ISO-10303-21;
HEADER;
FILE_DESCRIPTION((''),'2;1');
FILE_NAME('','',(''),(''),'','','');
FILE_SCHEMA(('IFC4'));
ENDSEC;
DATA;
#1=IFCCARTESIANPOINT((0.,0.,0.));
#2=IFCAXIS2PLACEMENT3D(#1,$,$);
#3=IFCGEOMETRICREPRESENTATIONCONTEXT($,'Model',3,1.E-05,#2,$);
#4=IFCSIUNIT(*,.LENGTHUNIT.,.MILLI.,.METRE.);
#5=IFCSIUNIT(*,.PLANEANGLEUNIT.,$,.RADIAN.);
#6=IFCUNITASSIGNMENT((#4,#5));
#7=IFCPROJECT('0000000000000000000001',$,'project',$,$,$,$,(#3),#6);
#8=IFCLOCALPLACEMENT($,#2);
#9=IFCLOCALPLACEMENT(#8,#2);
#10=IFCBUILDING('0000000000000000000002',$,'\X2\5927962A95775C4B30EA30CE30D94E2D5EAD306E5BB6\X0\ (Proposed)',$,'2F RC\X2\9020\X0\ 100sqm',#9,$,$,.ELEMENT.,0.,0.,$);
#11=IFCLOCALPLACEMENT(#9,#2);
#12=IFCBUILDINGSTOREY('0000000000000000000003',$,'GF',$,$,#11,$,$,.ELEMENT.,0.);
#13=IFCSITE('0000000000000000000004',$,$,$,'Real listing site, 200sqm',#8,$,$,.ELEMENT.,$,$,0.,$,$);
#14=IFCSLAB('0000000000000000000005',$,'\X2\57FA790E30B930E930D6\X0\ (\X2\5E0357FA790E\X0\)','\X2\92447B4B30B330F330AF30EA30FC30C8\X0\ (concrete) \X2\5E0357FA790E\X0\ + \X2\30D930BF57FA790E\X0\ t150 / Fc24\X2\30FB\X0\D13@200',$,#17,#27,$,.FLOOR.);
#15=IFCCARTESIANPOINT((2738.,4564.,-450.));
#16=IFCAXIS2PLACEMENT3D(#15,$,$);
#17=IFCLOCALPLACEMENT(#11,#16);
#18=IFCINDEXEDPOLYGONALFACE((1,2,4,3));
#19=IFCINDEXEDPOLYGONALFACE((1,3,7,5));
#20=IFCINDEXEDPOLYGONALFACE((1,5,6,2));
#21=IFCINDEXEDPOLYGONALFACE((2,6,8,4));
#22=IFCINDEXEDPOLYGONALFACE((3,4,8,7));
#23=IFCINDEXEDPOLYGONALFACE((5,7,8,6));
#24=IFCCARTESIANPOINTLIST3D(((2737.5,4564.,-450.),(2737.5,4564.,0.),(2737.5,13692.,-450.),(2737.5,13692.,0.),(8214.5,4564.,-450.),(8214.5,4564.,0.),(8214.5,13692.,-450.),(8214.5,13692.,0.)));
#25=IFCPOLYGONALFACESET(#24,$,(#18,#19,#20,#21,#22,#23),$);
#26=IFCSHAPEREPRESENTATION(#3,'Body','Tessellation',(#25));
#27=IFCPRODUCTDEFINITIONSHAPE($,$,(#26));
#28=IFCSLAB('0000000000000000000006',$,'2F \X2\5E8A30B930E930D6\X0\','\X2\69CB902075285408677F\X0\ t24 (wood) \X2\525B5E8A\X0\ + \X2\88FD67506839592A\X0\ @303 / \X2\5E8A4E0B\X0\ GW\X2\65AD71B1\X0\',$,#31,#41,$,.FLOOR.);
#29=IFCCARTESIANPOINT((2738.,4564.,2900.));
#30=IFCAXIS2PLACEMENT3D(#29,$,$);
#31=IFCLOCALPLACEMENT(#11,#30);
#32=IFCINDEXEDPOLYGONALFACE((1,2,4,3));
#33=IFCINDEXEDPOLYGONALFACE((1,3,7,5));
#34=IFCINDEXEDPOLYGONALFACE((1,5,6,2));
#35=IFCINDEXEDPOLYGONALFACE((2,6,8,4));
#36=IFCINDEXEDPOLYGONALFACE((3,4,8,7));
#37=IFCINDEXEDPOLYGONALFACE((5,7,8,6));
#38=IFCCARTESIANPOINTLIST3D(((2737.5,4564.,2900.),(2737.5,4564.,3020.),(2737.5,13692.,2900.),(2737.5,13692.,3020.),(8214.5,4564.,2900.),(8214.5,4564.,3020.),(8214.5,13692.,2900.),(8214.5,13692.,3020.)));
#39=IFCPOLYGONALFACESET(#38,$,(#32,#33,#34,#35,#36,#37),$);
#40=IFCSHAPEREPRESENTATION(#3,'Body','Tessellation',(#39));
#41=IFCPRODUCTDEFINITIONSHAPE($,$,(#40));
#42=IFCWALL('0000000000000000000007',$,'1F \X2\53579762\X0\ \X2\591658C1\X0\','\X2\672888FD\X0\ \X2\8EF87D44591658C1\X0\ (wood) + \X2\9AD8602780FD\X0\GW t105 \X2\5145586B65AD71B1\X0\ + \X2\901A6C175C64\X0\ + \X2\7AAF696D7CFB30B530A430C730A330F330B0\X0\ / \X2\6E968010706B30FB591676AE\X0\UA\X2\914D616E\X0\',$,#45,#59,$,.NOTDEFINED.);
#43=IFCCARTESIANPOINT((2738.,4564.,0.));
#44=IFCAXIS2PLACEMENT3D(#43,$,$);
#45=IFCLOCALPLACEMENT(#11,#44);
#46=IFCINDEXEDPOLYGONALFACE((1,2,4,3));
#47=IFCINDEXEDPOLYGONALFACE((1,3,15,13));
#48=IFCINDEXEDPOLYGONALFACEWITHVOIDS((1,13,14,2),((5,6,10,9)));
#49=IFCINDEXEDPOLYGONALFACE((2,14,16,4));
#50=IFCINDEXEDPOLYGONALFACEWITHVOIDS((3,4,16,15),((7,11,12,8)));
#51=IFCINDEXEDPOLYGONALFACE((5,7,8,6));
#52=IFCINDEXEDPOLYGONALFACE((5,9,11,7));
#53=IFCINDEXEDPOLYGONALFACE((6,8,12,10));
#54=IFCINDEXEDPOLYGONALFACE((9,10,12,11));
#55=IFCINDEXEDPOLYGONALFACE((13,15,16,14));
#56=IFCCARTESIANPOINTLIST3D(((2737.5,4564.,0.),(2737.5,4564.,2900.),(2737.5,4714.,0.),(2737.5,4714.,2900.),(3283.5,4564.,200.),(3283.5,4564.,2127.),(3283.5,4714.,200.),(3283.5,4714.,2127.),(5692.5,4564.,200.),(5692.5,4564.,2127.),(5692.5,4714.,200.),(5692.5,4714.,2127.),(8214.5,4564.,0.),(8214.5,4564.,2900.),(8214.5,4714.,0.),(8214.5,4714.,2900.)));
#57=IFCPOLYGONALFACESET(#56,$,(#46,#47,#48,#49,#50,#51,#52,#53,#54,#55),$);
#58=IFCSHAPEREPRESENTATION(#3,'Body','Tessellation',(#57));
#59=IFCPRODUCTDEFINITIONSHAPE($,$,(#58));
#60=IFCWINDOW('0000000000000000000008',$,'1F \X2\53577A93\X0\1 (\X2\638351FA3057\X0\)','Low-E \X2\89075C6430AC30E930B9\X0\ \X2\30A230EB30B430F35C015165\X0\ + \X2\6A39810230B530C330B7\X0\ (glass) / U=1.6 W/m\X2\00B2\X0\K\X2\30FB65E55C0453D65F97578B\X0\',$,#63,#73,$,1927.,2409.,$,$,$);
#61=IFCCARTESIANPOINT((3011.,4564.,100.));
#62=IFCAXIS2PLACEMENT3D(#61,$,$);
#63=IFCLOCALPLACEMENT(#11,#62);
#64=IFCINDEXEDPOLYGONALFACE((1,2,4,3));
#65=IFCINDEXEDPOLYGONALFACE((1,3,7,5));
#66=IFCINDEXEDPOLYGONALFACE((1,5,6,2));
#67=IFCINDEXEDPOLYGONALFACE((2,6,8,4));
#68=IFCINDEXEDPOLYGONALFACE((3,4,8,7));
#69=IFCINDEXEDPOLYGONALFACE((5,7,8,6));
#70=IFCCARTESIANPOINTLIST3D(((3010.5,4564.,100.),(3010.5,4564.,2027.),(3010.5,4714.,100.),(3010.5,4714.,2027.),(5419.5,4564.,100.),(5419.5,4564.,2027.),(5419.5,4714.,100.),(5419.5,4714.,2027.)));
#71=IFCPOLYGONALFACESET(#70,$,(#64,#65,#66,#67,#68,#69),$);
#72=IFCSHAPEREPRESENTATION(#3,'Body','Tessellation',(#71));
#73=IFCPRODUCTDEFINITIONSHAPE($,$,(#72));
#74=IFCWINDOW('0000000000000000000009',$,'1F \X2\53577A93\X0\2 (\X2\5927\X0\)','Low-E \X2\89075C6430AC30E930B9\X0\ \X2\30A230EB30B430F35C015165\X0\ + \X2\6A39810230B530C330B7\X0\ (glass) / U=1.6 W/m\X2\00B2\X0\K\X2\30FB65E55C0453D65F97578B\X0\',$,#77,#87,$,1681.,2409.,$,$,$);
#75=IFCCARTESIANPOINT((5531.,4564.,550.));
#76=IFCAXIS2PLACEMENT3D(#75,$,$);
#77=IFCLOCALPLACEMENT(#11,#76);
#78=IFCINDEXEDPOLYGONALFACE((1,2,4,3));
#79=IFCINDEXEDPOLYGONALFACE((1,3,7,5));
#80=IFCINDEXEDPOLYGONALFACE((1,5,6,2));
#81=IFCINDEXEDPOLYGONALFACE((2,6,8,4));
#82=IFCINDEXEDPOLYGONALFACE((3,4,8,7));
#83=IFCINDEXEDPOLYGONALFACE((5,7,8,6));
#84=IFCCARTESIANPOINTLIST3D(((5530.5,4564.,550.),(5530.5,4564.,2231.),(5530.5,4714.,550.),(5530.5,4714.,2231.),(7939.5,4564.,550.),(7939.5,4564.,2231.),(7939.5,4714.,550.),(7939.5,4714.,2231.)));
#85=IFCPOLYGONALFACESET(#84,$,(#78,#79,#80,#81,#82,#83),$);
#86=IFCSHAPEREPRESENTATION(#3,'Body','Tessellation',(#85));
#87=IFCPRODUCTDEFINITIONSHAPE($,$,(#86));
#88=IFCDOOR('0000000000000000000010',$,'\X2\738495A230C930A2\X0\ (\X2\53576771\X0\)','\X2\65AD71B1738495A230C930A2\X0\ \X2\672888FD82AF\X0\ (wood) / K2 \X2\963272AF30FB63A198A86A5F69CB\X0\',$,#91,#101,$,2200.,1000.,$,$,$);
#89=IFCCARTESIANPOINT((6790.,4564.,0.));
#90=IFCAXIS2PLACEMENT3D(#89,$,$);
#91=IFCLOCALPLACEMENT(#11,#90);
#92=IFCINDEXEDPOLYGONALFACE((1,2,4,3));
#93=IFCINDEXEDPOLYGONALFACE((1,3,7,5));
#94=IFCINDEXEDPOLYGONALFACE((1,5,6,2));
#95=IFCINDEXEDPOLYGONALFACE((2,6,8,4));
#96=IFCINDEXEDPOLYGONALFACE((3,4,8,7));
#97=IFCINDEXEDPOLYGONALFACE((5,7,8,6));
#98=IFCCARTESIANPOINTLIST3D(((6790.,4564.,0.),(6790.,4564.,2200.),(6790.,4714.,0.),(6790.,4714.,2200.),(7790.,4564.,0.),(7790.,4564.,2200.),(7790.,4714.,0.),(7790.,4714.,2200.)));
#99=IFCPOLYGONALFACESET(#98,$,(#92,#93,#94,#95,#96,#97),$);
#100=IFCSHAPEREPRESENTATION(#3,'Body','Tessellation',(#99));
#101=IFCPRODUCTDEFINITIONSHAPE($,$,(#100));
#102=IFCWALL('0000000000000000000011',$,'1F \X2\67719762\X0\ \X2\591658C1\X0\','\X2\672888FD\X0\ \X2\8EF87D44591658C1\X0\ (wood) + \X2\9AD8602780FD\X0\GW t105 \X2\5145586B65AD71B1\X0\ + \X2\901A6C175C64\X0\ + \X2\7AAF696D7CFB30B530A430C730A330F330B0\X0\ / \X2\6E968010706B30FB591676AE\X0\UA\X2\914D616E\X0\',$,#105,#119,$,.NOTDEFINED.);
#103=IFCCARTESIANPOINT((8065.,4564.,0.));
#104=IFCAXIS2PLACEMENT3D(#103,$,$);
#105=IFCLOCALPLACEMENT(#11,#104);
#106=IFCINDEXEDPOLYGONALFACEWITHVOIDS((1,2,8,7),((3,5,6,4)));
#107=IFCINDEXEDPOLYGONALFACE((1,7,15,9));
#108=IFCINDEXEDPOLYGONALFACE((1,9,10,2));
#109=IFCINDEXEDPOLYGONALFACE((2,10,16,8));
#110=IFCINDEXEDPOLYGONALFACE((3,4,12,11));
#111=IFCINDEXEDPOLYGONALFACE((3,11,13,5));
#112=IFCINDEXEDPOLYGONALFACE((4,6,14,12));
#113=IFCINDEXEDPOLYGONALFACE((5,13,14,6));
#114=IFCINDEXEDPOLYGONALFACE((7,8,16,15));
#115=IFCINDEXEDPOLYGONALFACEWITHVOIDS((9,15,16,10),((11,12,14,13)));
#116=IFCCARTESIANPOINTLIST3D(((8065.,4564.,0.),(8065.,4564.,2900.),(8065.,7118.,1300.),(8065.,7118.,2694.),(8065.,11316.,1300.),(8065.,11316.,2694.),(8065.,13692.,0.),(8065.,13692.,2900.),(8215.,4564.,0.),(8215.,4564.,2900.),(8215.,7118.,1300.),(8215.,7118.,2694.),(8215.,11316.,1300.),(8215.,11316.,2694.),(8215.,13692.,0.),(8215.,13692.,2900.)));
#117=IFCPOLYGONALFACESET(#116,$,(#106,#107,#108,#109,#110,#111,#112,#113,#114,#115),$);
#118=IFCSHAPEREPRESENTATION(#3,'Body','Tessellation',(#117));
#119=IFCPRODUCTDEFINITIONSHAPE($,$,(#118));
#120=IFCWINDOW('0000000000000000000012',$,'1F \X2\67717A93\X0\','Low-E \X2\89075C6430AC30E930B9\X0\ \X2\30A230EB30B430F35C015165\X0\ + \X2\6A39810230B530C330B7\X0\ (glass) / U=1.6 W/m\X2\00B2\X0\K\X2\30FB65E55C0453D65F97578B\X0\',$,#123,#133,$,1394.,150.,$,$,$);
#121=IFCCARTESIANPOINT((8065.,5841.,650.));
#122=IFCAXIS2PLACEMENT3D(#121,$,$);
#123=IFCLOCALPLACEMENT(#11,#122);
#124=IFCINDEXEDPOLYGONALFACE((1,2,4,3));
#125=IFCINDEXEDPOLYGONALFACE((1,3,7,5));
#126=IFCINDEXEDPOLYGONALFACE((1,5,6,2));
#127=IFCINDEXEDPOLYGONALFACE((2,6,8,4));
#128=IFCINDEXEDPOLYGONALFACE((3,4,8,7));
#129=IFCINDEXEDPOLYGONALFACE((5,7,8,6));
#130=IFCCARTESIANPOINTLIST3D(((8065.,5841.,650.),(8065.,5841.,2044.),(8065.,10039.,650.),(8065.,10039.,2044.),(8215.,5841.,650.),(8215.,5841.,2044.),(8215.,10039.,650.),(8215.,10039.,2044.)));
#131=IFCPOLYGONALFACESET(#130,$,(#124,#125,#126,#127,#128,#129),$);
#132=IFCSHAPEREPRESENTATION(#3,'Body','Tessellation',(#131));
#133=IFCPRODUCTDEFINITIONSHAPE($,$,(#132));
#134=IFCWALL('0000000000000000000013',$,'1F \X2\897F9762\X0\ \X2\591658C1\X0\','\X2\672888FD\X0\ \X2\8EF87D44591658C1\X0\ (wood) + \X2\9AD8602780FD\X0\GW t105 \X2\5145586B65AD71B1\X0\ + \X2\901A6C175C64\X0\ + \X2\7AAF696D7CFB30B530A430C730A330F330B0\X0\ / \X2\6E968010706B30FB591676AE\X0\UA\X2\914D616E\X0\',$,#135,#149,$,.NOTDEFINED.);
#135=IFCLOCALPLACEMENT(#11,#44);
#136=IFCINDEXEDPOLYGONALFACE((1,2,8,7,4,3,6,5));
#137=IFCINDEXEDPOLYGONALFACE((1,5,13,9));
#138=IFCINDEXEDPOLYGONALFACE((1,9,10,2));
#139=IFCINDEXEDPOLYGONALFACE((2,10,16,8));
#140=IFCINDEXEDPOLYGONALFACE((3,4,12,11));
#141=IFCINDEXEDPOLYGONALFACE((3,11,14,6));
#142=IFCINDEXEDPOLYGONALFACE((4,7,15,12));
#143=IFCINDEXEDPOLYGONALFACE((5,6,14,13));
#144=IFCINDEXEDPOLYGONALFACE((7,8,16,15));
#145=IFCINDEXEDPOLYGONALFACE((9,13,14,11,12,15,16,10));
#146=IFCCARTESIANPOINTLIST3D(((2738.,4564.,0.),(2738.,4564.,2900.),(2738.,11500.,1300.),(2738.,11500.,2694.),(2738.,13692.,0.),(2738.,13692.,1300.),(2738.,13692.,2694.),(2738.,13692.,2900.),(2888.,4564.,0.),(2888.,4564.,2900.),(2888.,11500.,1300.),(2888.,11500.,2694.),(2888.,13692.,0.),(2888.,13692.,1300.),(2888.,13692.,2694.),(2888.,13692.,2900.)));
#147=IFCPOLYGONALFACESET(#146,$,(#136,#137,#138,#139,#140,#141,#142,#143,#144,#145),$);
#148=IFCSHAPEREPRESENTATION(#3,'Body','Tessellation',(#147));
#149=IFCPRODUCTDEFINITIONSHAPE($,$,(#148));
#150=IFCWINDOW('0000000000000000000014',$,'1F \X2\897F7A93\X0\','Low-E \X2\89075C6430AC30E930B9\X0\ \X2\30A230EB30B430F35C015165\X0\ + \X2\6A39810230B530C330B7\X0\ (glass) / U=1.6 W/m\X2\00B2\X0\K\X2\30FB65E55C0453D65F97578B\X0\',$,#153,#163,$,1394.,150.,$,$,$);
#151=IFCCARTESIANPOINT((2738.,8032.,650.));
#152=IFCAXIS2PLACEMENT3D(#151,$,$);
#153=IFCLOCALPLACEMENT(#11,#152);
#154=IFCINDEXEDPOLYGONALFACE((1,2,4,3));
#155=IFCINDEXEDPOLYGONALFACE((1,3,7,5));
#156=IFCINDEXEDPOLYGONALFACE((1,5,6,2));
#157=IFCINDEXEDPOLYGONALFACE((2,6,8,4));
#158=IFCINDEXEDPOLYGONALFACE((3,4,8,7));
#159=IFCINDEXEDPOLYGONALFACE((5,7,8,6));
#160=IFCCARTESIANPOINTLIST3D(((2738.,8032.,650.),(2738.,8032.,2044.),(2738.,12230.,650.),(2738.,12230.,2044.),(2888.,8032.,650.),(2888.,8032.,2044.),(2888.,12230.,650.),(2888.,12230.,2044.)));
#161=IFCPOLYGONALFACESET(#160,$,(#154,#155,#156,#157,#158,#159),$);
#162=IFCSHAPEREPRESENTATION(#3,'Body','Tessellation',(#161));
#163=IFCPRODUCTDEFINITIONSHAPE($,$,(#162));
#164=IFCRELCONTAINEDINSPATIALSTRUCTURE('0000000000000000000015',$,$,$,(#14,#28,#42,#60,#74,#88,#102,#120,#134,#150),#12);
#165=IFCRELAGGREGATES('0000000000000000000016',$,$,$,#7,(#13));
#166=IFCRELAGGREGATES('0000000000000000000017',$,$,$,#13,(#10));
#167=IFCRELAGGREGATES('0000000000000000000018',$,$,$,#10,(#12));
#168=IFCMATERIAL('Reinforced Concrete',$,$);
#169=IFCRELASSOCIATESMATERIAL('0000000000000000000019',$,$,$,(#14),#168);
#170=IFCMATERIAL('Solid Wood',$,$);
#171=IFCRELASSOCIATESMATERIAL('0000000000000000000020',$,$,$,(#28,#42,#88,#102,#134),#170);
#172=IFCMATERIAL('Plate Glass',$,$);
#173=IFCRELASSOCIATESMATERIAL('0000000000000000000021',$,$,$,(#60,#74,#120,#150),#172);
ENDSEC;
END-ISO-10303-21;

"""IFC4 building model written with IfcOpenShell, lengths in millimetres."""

from ifc_helpers import new_model, si_unit, frame, frame_2d, origin, place, context, project, spatial, rectangle, extrude, material, element, fill, save


model = new_model("IFC4")

# Units and contexts
model_context = context("Model", 3, precision=1e-05, world=origin())
ifc_project = project(units=[si_unit("LENGTHUNIT", "METRE", prefix="MILLI"), si_unit("PLANEANGLEUNIT", "RADIAN")], contexts=[model_context])

# Site, building, storey
site_placement = place(None, origin())
site = spatial("IfcSite", under=ifc_project, at=site_placement, ObjectType="Real listing site, 200sqm", CompositionType="ELEMENT", RefElevation=0.0)
building_placement = place(site_placement, origin())
building = spatial("IfcBuilding", under=site, at=building_placement, Name="大阪長屋リノベ中庭の家 (Proposed)", ObjectType="2F RC造 100sqm", CompositionType="ELEMENT", ElevationOfRefHeight=0.0, ElevationOfTerrain=0.0)
storey_placement = place(building_placement, origin())
storey = spatial("IfcBuildingStorey", under=building, at=storey_placement, Name="GF", CompositionType="ELEMENT", Elevation=0.0)

# Slabs
ifc_material_1 = material(Name="Reinforced Concrete")
slab_1_placement = place(storey_placement, frame((2738.0, 4564.0, -450.0)))
element("IfcSlab", 1, at=slab_1_placement, inside=storey, material=ifc_material_1, Name="基礎スラブ (布基礎)", Description="鉄筋コンクリート (concrete) 布基礎 + ベタ基礎 t150 / Fc24・D13@200", PredefinedType="FLOOR", context=model_context, shape_type="SweptSolid", body=[
    extrude(rectangle(XDim=5477.0, YDim=9128.0, at=frame_2d((2738.0, 4564.0))), frame((2738.0, 4564.0, -450.0)), (0.0, 0.0, 1.0), 450.0),
])
ifc_material_2 = material(Name="Solid Wood")
slab_2_placement = place(storey_placement, frame((2738.0, 4564.0, 2900.0)))
element("IfcSlab", 2, at=slab_2_placement, inside=storey, material=ifc_material_2, Name="2F 床スラブ", Description="構造用合板 t24 (wood) 剛床 + 製材根太 @303 / 床下 GW断熱", PredefinedType="FLOOR", context=model_context, shape_type="SweptSolid", body=[
    extrude(rectangle(XDim=5477.0, YDim=9128.0, at=frame_2d((2738.0, 4564.0))), frame((2738.0, 4564.0, 2900.0)), (0.0, 0.0, 1.0), 120.0),
])

# Wall, openings, windows, door
wall_1_placement = place(storey_placement, frame((2738.0, 4564.0, 0.0)))
wall_1 = element("IfcWall", 3, at=wall_1_placement, inside=storey, material=ifc_material_2, Name="1F 南面 外壁", Description="木製 軸組外壁 (wood) + 高性能GW t105 充填断熱 + 通気層 + 窯業系サイディング / 準耐火・外皮UA配慮", PredefinedType="NOTDEFINED", context=model_context, shape_type="SweptSolid", body=[
    extrude(rectangle(XDim=5477.0, YDim=150.0, at=frame_2d((2738.0, 75.0))), frame((2738.0, 4564.0, 0.0)), (0.0, 0.0, 1.0), 2900.0),
])
opening_1_placement = place(storey_placement, frame((3011.0, 4564.0, 100.0)))
opening_1 = element("IfcOpeningElement", 4, at=opening_1_placement, cuts=wall_1, PredefinedType="NOTDEFINED", context=model_context, shape_type="SweptSolid", body=[
    extrude(rectangle(XDim=2409.0, YDim=150.0, at=frame_2d((1204.0, 75.0))), frame((3011.0, 4564.0, 100.0)), (0.0, 0.0, 1.0), 1927.0),
])
opening_2_placement = place(storey_placement, frame((5531.0, 4564.0, 550.0)))
opening_2 = element("IfcOpeningElement", 5, at=opening_2_placement, cuts=wall_1, PredefinedType="NOTDEFINED", context=model_context, shape_type="SweptSolid", body=[
    extrude(rectangle(XDim=2409.0, YDim=150.0, at=frame_2d((1204.0, 75.0))), frame((5531.0, 4564.0, 550.0)), (0.0, 0.0, 1.0), 1681.0),
])
opening_3_placement = place(storey_placement, frame((6790.0, 4564.0, 0.0)))
opening_3 = element("IfcOpeningElement", 6, at=opening_3_placement, cuts=wall_1, PredefinedType="NOTDEFINED", context=model_context, shape_type="SweptSolid", body=[
    extrude(rectangle(XDim=1000.0, YDim=150.0, at=frame_2d((500.0, 75.0))), frame((6790.0, 4564.0, 0.0)), (0.0, 0.0, 1.0), 2200.0),
])
ifc_material_3 = material(Name="Plate Glass")
window_1_placement = place(storey_placement, frame((3011.0, 4564.0, 100.0)))
window_1 = element("IfcWindow", 7, at=window_1_placement, inside=storey, material=ifc_material_3, Name="1F 南窓1 (掃出し)", Description="Low-E 複層ガラス アルゴン封入 + 樹脂サッシ (glass) / U=1.6 W/m²K・日射取得型", OverallHeight=1927.0, OverallWidth=2409.0, context=model_context, shape_type="SweptSolid", body=[
    extrude(rectangle(XDim=2409.0, YDim=150.0, at=frame_2d((1204.0, 75.0))), frame((3011.0, 4564.0, 100.0)), (0.0, 0.0, 1.0), 1927.0),
])
fill(opening_1, window_1)
window_2_placement = place(storey_placement, frame((5531.0, 4564.0, 550.0)))
window_2 = element("IfcWindow", 8, at=window_2_placement, inside=storey, material=ifc_material_3, Name="1F 南窓2 (大)", Description="Low-E 複層ガラス アルゴン封入 + 樹脂サッシ (glass) / U=1.6 W/m²K・日射取得型", OverallHeight=1681.0, OverallWidth=2409.0, context=model_context, shape_type="SweptSolid", body=[
    extrude(rectangle(XDim=2409.0, YDim=150.0, at=frame_2d((1204.0, 75.0))), frame((5531.0, 4564.0, 550.0)), (0.0, 0.0, 1.0), 1681.0),
])
fill(opening_2, window_2)
door_placement = place(storey_placement, frame((6790.0, 4564.0, 0.0)))
door = element("IfcDoor", 9, at=door_placement, inside=storey, material=ifc_material_2, Name="玄関ドア (南東)", Description="断熱玄関ドア 木製芯 (wood) / K2 防犯・採風機構", OverallHeight=2200.0, OverallWidth=1000.0, context=model_context, shape_type="SweptSolid", body=[
    extrude(rectangle(XDim=1000.0, YDim=150.0, at=frame_2d((500.0, 75.0))), frame((6790.0, 4564.0, 0.0)), (0.0, 0.0, 1.0), 2200.0),
])
fill(opening_3, door)

# Walls, openings, windows
wall_2_placement = place(storey_placement, frame((8065.0, 4564.0, 0.0)))
wall_2 = element("IfcWall", 10, at=wall_2_placement, inside=storey, material=ifc_material_2, Name="1F 東面 外壁", Description="木製 軸組外壁 (wood) + 高性能GW t105 充填断熱 + 通気層 + 窯業系サイディング / 準耐火・外皮UA配慮", PredefinedType="NOTDEFINED", context=model_context, shape_type="SweptSolid", body=[
    extrude(rectangle(XDim=150.0, YDim=9128.0, at=frame_2d((75.0, 4564.0))), frame((8065.0, 4564.0, 0.0)), (0.0, 0.0, 1.0), 2900.0),
])
opening_4_placement = place(storey_placement, frame((8065.0, 5841.0, 650.0)))
opening_4 = element("IfcOpeningElement", 11, at=opening_4_placement, cuts=wall_2, PredefinedType="NOTDEFINED", context=model_context, shape_type="SweptSolid", body=[
    extrude(rectangle(XDim=150.0, YDim=4198.0, at=frame_2d((75.0, 2099.0))), frame((8065.0, 5841.0, 650.0)), (0.0, 0.0, 1.0), 1394.0),
])
window_3_placement = place(storey_placement, frame((8065.0, 5841.0, 650.0)))
window_3 = element("IfcWindow", 12, at=window_3_placement, inside=storey, material=ifc_material_3, Name="1F 東窓", Description="Low-E 複層ガラス アルゴン封入 + 樹脂サッシ (glass) / U=1.6 W/m²K・日射取得型", OverallHeight=1394.0, OverallWidth=150.0, context=model_context, shape_type="SweptSolid", body=[
    extrude(rectangle(XDim=150.0, YDim=4198.0, at=frame_2d((75.0, 2099.0))), frame((8065.0, 5841.0, 650.0)), (0.0, 0.0, 1.0), 1394.0),
])
fill(opening_4, window_3)
wall_3_placement = place(storey_placement, frame((2738.0, 4564.0, 0.0)))
wall_3 = element("IfcWall", 13, at=wall_3_placement, inside=storey, material=ifc_material_2, Name="1F 西面 外壁", Description="木製 軸組外壁 (wood) + 高性能GW t105 充填断熱 + 通気層 + 窯業系サイディング / 準耐火・外皮UA配慮", PredefinedType="NOTDEFINED", context=model_context, shape_type="SweptSolid", body=[
    extrude(rectangle(XDim=150.0, YDim=9128.0, at=frame_2d((75.0, 4564.0))), frame((2738.0, 4564.0, 0.0)), (0.0, 0.0, 1.0), 2900.0),
])
opening_5_placement = place(storey_placement, frame((2738.0, 8032.0, 650.0)))
opening_5 = element("IfcOpeningElement", 14, at=opening_5_placement, cuts=wall_3, PredefinedType="NOTDEFINED", context=model_context, shape_type="SweptSolid", body=[
    extrude(rectangle(XDim=150.0, YDim=4198.0, at=frame_2d((75.0, 2099.0))), frame((2738.0, 8032.0, 650.0)), (0.0, 0.0, 1.0), 1394.0),
])
window_4_placement = place(storey_placement, frame((2738.0, 8032.0, 650.0)))
window_4 = element("IfcWindow", 15, at=window_4_placement, inside=storey, material=ifc_material_3, Name="1F 西窓", Description="Low-E 複層ガラス アルゴン封入 + 樹脂サッシ (glass) / U=1.6 W/m²K・日射取得型", OverallHeight=1394.0, OverallWidth=150.0, context=model_context, shape_type="SweptSolid", body=[
    extrude(rectangle(XDim=150.0, YDim=4198.0, at=frame_2d((75.0, 2099.0))), frame((2738.0, 8032.0, 650.0)), (0.0, 0.0, 1.0), 1394.0),
])
fill(opening_5, window_4)

save(model, "model.ifc")
